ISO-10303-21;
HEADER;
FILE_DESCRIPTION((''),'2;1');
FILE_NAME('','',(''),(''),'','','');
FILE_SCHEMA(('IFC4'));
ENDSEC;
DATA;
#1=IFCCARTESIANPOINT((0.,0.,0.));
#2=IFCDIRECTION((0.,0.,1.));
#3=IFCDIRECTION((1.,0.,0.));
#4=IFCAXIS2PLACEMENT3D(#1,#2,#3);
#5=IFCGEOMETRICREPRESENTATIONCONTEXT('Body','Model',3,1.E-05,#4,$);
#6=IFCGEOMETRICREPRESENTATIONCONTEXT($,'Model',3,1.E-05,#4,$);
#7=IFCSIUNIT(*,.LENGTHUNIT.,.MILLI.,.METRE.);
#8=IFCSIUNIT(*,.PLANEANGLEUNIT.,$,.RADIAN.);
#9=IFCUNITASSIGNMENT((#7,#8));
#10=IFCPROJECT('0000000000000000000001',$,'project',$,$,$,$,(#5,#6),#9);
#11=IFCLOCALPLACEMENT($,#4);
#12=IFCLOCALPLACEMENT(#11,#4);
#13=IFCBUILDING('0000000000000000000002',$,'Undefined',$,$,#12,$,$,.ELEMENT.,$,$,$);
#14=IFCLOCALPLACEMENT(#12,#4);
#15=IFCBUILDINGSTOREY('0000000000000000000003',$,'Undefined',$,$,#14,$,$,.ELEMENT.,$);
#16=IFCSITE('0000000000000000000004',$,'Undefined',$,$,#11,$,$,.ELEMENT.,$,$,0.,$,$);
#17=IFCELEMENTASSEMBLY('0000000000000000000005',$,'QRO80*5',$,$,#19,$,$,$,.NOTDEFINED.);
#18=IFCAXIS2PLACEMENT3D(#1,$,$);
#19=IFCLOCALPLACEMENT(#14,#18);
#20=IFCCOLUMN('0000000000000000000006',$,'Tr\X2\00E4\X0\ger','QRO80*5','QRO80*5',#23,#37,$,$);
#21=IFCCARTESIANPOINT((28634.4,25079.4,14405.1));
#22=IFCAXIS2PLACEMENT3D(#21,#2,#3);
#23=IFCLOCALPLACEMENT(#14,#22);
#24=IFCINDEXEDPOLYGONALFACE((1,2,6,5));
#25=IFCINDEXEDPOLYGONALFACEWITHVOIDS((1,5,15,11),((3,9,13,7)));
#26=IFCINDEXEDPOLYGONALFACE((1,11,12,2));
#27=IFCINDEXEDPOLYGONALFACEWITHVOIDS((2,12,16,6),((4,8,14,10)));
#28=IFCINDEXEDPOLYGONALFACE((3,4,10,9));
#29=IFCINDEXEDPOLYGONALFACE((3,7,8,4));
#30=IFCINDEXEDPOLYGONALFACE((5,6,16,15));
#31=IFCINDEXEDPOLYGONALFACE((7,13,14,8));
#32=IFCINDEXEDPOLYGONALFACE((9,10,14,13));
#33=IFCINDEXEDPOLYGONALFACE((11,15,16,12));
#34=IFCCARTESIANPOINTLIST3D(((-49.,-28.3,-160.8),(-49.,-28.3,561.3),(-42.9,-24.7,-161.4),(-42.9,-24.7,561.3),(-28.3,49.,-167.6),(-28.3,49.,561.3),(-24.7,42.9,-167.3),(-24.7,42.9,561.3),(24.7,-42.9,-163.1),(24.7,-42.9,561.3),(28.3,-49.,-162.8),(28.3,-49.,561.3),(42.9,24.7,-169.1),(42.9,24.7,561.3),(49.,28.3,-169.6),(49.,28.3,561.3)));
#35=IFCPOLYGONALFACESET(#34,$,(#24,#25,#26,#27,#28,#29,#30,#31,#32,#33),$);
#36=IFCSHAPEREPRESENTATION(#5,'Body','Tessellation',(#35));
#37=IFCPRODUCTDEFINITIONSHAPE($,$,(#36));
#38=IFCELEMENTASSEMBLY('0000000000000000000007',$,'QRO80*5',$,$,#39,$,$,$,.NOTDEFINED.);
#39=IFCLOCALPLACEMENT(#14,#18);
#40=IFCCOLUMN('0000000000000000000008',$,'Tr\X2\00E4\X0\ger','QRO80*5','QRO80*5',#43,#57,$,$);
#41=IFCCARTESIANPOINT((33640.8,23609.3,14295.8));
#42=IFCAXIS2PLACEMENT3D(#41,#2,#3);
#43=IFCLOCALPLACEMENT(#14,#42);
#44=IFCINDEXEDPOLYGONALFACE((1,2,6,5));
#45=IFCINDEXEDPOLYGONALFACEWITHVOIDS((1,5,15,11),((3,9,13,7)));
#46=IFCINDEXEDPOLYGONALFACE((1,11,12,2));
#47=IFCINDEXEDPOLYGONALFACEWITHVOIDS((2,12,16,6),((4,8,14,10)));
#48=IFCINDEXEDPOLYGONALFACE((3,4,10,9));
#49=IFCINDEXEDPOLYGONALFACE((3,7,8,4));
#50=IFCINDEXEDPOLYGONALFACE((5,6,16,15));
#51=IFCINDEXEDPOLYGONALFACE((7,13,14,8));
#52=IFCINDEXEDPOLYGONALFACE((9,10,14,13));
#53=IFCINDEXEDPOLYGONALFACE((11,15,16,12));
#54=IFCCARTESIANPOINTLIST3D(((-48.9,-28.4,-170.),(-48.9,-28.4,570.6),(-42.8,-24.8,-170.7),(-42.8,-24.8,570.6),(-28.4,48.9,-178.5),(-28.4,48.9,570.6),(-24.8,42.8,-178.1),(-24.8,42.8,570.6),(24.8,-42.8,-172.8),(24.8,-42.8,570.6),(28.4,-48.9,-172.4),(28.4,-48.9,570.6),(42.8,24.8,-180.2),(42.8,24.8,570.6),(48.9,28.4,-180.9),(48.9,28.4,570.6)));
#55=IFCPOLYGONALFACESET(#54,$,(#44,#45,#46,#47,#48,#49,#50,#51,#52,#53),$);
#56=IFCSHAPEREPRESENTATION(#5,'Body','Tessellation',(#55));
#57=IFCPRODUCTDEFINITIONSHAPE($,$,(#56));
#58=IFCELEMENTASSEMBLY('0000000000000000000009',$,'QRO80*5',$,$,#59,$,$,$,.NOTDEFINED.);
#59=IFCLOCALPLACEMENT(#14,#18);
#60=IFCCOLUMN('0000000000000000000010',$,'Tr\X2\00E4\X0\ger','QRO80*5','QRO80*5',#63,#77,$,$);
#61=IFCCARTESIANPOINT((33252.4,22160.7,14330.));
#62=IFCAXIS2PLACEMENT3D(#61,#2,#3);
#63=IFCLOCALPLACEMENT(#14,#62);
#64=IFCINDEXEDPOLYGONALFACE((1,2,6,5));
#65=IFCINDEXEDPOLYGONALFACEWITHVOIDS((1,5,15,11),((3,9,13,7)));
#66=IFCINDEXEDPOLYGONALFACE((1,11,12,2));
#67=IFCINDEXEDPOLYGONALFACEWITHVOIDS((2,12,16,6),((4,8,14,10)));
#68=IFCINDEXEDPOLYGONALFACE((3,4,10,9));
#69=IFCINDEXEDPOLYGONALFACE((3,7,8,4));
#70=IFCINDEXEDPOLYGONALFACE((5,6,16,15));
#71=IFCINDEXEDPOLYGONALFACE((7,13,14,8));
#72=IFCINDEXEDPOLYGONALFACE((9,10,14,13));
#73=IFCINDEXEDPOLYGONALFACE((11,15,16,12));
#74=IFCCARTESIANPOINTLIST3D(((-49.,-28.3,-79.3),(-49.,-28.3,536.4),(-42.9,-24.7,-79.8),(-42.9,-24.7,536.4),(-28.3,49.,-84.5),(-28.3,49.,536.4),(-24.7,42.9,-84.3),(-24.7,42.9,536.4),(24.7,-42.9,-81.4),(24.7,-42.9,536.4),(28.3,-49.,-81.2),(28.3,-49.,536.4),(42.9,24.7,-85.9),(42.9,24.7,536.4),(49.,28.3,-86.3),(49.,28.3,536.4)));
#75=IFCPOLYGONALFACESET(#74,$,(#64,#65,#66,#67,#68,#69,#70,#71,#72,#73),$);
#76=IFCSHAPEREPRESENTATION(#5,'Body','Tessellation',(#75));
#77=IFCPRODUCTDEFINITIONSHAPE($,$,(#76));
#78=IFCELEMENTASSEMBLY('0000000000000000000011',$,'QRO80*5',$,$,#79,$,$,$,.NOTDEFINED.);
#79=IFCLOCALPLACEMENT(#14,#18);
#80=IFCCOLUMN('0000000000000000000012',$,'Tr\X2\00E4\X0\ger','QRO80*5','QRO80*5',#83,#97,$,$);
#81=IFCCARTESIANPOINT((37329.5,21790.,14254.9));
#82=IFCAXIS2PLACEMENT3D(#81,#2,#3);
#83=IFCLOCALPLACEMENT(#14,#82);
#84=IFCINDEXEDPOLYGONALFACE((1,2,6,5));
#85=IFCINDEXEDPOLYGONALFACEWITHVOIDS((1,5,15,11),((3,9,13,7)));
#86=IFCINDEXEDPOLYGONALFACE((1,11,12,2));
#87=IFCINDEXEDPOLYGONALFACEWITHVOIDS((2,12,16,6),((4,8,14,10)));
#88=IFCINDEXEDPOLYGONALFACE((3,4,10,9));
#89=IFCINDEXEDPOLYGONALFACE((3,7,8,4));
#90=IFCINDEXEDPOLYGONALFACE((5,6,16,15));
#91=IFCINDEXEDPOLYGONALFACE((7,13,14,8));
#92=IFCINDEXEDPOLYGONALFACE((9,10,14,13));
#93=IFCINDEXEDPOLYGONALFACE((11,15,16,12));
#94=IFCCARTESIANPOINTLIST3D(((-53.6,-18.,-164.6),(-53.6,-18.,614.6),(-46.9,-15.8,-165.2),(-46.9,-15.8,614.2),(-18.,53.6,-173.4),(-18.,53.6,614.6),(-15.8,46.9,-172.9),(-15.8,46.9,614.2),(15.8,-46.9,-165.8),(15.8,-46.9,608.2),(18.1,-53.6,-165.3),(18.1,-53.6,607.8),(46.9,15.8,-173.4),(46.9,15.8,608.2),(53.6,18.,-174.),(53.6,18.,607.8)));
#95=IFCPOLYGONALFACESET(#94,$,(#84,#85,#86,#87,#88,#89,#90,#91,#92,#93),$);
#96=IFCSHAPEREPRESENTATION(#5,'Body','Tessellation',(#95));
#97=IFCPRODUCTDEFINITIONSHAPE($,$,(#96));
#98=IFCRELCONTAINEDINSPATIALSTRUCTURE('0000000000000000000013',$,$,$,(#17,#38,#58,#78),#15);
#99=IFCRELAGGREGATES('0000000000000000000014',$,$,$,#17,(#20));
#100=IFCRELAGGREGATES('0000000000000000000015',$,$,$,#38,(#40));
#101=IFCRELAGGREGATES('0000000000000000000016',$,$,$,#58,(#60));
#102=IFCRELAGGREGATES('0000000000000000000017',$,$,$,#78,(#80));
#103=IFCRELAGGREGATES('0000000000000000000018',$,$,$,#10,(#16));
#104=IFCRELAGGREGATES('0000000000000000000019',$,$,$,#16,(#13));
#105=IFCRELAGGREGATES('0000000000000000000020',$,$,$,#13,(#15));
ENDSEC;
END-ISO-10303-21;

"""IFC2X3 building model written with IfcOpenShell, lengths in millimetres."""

from ifc_helpers import new_model, si_unit, frame, origin_with_axes, origin_2d_with_axis, place, context, project, spatial, hollow_rectangle, extrude, clip, halfspace, element, aggregate, save


model = new_model("IFC2X3")

# Units and contexts
model_context_1 = context("Model", 3, precision=1e-05, world=origin_with_axes(), identifier="Body")
model_context_2 = context("Model", 3, precision=1e-05, world=origin_with_axes())
ifc_project = project(units=[si_unit("LENGTHUNIT", "METRE", prefix="MILLI"), si_unit("PLANEANGLEUNIT", "RADIAN")], contexts=[model_context_1, model_context_2])

# Site, building, storey
site_placement = place(None, origin_with_axes())
site = spatial("IfcSite", under=ifc_project, at=site_placement, Name="Undefined", CompositionType="ELEMENT", RefElevation=0.0)
building_placement = place(site_placement, origin_with_axes())
building = spatial("IfcBuilding", under=site, at=building_placement, Name="Undefined", CompositionType="ELEMENT")
storey_placement = place(building_placement, origin_with_axes())
storey = spatial("IfcBuildingStorey", under=building, at=storey_placement, Name="Undefined", CompositionType="ELEMENT")

# Element assemblies, columns
assembly_1 = element("IfcElementAssembly", 1, inside=storey, Name="QRO80*5", PredefinedType="NOTDEFINED")
column_1_placement = place(storey_placement, frame((28634.4, 25079.4, 14405.1), z_axis=(0.0, 0.0, 1.0), x_axis=(1.0, 0.0, 0.0)))
column_1 = element("IfcColumn", 2, at=column_1_placement, Name="Träger", Description="QRO80*5", ObjectType="QRO80*5", context=model_context_1, shape_type="Clipping", body=[
    clip(clip(extrude(hollow_rectangle(XDim=80.0, YDim=80.0, WallThickness=5.0, at=origin_2d_with_axis()), frame((0.0, 0.0, 561.3), z_axis=(0.0, 0.0, -1.0), x_axis=(-0.25892, -0.965899, 0.000004)), (0.0, 0.0, 1.0), 731.0), halfspace(frame((38.6, -10.4, -166.2), z_axis=(0.045938, 0.075868, 0.996059), x_axis=(-0.255938, -0.962936, 0.085149)), True)), halfspace(frame((38.6, -10.4, 561.3), z_axis=(0.0, 0.0, -1.0), x_axis=(0.258815, 0.965927, 0.000003)), True)),
])
aggregate(assembly_1, [column_1])
assembly_2 = element("IfcElementAssembly", 3, inside=storey, Name="QRO80*5", PredefinedType="NOTDEFINED")
column_2_placement = place(storey_placement, frame((33640.8, 23609.3, 14295.8), z_axis=(0.0, 0.0, 1.0), x_axis=(1.0, 0.0, 0.0)))
column_2 = element("IfcColumn", 4, at=column_2_placement, Name="Träger", Description="QRO80*5", ObjectType="QRO80*5", context=model_context_1, shape_type="Clipping", body=[
    clip(clip(extrude(hollow_rectangle(XDim=80.0, YDim=80.0, WallThickness=5.0, at=origin_2d_with_axis()), frame((0.0, 0.0, 570.6), z_axis=(0.0, 0.0, -1.0), x_axis=(-0.256576, -0.966524, 0.000001)), (0.0, 0.0, 1.0), 751.5), halfspace(frame((35.1, -17.4, -175.8), z_axis=(0.055557, 0.09362, 0.994057), x_axis=(-0.440717, -0.891059, 0.108551)), True)), halfspace(frame((38.6, -10.4, 570.6), z_axis=(-0.000017, 0.000005, -1.0), x_axis=(0.258815, 0.965927, 0.000003)), True)),
])
aggregate(assembly_2, [column_2])
assembly_3 = element("IfcElementAssembly", 5, inside=storey, Name="QRO80*5", PredefinedType="NOTDEFINED")
column_3_placement = place(storey_placement, frame((33252.4, 22160.7, 14330.0), z_axis=(0.0, 0.0, 1.0), x_axis=(1.0, 0.0, 0.0)))
column_3 = element("IfcColumn", 6, at=column_3_placement, Name="Träger", Description="QRO80*5", ObjectType="QRO80*5", context=model_context_1, shape_type="Clipping", body=[
    clip(clip(extrude(hollow_rectangle(XDim=80.0, YDim=80.0, WallThickness=5.0, at=origin_2d_with_axis()), frame((0.0, 0.0, 536.4), z_axis=(0.0, 0.0, -1.0), x_axis=(-0.25892, -0.965899, 0.000004)), (0.0, 0.0, 1.0), 622.7), halfspace(frame((36.6, -15.3, -83.4), z_axis=(0.038673, 0.0558, 0.997693), x_axis=(-0.383122, -0.92131, 0.066378)), True)), halfspace(frame((38.6, -10.4, 536.4), z_axis=(-0.000017, 0.000005, -1.0), x_axis=(0.258841, 0.96592, 0.0)), True)),
])
aggregate(assembly_3, [column_3])
assembly_4 = element("IfcElementAssembly", 7, inside=storey, Name="QRO80*5", PredefinedType="NOTDEFINED")
column_4_placement = place(storey_placement, frame((37329.5, 21790.0, 14254.9), z_axis=(0.0, 0.0, 1.0), x_axis=(1.0, 0.0, 0.0)))
column_4 = element("IfcColumn", 8, at=column_4_placement, Name="Träger", Description="QRO80*5", ObjectType="QRO80*5", context=model_context_1, shape_type="Clipping", body=[
    clip(clip(extrude(hollow_rectangle(XDim=80.0, YDim=80.0, WallThickness=5.0, at=origin_2d_with_axis()), frame((0.0, 0.0, 619.4), z_axis=(0.0, 0.0, -1.0), x_axis=(-0.895769, 0.444521, 0.000002)), (0.0, 0.0, 1.0), 796.9), halfspace(frame((35.8, -17.8, -169.7), z_axis=(0.055557, 0.09362, 0.994057), x_axis=(-0.440717, -0.891059, 0.108551)), True)), halfspace(frame((17.8, 35.8, 611.2), z_axis=(-0.076083, 0.037747, -0.996387), x_axis=(-0.892532, 0.442915, 0.084932)), True)),
])
aggregate(assembly_4, [column_4])

save(model, "model.ifc")
